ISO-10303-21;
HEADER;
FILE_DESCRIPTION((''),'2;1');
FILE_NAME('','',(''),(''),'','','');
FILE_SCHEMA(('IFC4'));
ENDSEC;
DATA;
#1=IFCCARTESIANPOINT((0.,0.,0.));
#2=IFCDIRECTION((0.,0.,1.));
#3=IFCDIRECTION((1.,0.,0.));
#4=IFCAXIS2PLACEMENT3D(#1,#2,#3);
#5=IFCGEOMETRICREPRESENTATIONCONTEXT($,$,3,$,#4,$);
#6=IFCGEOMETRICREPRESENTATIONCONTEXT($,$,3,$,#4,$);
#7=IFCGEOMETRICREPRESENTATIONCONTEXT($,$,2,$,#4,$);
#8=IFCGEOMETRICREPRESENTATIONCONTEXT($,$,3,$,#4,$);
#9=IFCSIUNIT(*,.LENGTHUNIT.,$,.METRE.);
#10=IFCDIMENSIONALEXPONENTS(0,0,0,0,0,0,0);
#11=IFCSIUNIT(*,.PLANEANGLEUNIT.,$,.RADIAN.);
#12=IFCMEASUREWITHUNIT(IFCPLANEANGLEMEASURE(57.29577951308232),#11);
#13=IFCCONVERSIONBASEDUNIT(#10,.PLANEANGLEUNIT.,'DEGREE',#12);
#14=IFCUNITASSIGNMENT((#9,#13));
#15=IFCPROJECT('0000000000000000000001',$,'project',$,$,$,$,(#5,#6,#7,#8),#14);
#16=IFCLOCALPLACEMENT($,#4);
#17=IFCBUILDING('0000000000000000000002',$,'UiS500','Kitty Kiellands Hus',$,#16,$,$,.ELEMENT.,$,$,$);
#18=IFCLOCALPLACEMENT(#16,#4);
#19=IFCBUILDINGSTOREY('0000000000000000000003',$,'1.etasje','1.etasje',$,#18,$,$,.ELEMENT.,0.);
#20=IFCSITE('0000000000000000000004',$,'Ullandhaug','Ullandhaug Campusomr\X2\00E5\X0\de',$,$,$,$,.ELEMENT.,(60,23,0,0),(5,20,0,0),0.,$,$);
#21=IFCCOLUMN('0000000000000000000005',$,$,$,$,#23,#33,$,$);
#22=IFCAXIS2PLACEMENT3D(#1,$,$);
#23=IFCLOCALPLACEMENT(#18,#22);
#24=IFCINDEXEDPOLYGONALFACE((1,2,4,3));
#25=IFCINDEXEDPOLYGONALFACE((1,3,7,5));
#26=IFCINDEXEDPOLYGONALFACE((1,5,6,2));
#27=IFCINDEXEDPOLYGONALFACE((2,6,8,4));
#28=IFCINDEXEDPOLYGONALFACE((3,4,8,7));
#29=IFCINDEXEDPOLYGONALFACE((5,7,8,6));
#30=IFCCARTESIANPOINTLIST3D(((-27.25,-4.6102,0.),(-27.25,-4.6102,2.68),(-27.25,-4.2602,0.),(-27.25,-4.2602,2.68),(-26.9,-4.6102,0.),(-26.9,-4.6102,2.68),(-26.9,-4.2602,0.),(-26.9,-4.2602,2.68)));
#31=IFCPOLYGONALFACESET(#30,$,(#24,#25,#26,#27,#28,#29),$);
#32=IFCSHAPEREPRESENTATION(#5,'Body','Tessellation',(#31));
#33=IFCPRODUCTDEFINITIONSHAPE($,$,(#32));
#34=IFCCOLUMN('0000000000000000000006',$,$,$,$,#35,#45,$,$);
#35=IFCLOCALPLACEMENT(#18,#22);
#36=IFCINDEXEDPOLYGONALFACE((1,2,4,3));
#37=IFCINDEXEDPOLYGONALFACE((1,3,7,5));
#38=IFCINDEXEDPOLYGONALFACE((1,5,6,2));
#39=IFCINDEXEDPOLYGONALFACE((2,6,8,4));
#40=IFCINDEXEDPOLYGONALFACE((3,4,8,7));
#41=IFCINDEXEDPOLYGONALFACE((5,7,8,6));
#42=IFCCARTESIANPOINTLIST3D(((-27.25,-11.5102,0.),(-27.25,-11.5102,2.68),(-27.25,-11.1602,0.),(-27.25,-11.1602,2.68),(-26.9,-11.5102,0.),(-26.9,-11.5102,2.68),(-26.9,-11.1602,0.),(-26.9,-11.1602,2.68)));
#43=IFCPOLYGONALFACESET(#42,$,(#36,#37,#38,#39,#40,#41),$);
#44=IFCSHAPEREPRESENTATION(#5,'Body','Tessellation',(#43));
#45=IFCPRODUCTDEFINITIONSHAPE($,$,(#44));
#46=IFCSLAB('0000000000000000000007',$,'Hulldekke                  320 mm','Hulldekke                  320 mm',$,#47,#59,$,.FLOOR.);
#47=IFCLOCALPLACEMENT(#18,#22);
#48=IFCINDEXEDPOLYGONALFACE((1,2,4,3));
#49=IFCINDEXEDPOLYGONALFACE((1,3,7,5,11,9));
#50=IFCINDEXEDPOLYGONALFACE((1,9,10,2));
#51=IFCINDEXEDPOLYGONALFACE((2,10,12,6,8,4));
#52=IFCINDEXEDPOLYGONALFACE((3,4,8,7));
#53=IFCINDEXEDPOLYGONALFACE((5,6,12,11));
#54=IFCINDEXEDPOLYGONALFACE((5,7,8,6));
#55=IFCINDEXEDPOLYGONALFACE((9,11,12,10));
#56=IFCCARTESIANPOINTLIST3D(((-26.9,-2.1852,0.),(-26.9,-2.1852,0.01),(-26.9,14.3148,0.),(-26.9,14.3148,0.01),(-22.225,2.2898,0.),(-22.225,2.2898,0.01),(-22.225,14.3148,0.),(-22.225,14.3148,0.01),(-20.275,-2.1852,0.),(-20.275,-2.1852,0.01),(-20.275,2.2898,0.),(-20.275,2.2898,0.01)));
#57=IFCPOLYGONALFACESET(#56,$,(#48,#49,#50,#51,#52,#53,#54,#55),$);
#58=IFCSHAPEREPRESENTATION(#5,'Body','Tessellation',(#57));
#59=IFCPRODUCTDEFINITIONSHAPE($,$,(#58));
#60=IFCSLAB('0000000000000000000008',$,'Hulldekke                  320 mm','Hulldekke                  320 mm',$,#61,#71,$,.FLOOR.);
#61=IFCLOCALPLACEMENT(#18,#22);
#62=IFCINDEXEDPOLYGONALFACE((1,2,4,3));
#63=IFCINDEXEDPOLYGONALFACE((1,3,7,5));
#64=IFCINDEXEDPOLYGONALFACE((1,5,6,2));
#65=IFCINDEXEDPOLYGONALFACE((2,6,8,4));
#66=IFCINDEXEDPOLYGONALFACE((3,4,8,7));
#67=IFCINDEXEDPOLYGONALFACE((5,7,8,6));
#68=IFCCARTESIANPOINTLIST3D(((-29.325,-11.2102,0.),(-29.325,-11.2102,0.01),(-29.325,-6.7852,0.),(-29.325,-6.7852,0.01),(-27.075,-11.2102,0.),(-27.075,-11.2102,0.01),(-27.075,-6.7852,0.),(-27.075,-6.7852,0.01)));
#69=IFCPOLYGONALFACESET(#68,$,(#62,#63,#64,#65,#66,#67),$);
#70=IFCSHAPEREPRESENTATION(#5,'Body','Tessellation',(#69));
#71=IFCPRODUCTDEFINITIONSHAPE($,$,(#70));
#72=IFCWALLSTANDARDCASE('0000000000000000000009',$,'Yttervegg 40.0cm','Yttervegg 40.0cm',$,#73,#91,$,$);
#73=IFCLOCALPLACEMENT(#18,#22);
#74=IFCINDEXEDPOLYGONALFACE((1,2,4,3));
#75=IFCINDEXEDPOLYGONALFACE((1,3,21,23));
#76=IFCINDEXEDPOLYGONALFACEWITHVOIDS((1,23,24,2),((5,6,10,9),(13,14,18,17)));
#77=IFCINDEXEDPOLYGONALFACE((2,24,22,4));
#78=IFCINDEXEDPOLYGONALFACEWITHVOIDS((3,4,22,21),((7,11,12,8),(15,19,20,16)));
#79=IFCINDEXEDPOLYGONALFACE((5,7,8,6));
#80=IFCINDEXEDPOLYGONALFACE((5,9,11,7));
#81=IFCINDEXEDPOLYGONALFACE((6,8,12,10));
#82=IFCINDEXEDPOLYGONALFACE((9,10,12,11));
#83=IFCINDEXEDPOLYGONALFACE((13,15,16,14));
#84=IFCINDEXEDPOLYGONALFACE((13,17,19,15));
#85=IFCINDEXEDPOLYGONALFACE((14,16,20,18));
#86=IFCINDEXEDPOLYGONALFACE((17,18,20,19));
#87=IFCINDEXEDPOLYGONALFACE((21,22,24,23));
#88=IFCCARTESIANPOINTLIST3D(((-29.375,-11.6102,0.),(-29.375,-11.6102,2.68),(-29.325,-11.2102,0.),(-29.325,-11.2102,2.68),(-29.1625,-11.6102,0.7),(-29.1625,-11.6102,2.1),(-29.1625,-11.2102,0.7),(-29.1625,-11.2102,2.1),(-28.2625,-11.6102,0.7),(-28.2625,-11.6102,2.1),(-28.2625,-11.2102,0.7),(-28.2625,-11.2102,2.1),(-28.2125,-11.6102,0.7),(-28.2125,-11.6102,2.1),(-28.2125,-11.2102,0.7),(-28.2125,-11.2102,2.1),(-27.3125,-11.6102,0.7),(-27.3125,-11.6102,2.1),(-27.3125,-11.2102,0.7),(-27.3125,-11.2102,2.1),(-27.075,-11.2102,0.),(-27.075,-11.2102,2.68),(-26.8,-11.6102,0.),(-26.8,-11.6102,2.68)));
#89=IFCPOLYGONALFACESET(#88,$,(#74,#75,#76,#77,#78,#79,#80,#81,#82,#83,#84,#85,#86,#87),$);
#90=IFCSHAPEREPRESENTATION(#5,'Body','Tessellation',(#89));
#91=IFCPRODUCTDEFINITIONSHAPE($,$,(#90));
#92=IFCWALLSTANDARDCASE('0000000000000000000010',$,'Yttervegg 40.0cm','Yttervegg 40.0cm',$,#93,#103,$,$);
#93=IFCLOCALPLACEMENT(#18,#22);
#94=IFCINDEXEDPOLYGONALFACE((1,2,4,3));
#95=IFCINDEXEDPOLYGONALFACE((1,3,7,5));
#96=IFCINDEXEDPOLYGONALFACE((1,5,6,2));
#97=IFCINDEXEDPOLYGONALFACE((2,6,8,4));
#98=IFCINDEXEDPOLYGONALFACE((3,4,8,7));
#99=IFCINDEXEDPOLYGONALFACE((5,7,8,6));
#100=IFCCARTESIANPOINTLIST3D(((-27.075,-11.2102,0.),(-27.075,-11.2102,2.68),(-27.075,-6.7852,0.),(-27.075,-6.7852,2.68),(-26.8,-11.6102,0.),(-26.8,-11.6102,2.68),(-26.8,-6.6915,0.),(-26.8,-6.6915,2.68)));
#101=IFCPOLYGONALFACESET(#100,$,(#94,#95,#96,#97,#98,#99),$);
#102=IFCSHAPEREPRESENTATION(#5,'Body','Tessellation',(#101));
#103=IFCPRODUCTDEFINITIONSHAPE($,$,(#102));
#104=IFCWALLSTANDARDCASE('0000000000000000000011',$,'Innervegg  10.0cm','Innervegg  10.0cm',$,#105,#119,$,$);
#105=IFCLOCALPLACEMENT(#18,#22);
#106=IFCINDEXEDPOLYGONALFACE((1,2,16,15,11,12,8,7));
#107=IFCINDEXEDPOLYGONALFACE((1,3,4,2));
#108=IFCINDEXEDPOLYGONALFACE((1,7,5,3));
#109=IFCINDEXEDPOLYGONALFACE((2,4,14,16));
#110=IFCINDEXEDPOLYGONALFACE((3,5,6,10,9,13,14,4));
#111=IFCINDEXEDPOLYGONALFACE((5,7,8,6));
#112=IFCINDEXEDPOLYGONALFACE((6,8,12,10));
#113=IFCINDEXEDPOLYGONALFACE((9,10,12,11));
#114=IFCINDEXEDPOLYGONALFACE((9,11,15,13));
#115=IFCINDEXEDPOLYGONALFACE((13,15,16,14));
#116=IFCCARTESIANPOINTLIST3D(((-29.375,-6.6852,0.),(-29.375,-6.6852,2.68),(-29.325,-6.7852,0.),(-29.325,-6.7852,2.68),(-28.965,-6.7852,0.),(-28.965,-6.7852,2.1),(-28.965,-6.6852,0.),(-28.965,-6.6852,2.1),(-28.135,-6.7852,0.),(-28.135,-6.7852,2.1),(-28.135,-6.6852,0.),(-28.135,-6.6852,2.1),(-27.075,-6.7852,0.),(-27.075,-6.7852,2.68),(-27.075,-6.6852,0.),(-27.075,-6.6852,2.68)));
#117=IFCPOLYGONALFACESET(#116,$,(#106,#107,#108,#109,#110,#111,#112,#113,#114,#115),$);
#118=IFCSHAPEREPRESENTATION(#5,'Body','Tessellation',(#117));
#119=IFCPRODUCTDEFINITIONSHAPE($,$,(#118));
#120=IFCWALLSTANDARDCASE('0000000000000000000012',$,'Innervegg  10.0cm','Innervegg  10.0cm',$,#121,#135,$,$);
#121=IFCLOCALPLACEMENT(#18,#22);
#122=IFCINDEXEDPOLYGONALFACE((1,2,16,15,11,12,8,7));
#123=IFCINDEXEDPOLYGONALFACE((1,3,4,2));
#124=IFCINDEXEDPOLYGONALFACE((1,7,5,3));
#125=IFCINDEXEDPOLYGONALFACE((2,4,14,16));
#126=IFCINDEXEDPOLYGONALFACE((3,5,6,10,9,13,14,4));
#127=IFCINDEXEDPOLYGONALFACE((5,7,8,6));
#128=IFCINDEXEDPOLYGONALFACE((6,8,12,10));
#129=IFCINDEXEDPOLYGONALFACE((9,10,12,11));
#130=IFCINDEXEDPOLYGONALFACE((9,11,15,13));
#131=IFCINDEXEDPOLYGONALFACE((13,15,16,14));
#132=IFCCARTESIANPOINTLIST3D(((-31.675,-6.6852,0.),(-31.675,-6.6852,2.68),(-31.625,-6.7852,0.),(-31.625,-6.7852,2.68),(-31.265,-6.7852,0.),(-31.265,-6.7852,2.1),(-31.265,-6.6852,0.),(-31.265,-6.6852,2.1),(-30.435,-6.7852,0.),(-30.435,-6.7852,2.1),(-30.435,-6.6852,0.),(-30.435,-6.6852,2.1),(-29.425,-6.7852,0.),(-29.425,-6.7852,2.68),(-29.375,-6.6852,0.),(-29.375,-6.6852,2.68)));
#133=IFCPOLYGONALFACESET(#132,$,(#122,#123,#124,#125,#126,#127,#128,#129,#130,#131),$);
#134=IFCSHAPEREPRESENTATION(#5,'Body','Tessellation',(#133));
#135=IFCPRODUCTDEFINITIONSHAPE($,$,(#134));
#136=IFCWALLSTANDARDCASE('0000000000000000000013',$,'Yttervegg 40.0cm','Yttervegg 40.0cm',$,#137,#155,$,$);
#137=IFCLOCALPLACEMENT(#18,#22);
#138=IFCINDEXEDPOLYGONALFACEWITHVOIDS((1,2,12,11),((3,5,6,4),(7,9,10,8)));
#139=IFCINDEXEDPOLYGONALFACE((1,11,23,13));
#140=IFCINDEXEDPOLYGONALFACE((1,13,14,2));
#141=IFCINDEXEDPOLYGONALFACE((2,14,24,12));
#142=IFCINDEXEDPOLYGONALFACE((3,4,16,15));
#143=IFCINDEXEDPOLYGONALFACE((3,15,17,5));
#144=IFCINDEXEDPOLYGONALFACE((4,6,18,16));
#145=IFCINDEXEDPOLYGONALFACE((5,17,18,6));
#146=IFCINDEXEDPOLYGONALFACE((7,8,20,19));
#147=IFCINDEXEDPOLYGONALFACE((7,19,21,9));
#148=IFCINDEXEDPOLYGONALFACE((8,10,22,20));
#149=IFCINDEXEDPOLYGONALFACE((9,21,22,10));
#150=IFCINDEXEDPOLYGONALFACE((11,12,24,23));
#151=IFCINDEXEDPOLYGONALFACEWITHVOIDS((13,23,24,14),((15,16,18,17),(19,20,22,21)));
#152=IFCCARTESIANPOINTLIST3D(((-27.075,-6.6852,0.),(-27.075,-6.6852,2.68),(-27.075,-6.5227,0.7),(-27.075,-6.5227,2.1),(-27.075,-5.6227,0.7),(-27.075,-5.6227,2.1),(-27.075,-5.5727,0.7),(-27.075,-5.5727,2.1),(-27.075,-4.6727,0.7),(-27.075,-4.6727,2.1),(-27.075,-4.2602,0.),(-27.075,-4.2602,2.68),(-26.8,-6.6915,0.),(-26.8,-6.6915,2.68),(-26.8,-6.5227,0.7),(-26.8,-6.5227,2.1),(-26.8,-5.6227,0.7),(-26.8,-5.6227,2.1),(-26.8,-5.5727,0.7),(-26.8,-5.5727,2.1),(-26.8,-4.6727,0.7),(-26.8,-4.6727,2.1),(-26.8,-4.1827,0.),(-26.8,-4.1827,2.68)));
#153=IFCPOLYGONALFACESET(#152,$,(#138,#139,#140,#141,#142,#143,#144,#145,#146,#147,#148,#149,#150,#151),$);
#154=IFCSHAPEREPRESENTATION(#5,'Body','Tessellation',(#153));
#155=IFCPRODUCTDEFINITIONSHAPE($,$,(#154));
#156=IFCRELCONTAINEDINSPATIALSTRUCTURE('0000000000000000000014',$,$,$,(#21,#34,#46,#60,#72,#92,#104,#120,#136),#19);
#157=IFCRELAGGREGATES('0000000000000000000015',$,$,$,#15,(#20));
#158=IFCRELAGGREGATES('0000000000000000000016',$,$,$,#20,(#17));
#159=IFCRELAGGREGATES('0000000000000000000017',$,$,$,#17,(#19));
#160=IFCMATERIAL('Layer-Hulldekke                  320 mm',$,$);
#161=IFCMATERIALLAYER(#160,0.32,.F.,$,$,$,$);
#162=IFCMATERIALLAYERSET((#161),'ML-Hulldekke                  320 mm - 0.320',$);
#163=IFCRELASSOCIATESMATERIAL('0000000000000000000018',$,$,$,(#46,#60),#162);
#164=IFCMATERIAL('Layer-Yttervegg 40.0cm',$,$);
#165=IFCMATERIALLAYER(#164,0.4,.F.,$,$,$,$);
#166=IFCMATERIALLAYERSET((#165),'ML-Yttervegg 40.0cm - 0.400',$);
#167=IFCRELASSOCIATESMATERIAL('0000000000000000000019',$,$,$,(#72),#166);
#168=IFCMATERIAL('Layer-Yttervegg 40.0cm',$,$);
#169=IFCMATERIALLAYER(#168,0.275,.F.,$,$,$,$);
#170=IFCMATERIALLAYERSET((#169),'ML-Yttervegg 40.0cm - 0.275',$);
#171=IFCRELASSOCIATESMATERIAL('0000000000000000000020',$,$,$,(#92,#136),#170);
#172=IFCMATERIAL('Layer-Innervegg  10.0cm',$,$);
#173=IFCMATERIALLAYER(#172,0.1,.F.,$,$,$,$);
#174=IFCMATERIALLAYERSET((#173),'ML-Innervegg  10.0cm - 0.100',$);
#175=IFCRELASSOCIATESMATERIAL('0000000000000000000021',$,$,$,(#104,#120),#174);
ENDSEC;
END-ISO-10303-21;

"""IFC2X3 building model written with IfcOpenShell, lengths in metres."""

from ifc_helpers import new_model, entity, si_unit, converted_unit, frame, origin_with_axes, origin_2d_with_axis, place, context, project, spatial, polyline, rectangle, outline, extrude, material, layer, layer_set, layer_usage, element, save


model = new_model("IFC2X3")

# Units and contexts
context_of_model_1 = context(None, 3, world=origin_with_axes())
context_of_model_2 = context(None, 3, world=origin_with_axes())
context_of_model_3 = context(None, 2, world=origin_with_axes())
context_of_model_4 = context(None, 3, world=origin_with_axes())
ifc_project = project(units=[si_unit("LENGTHUNIT", "METRE"), converted_unit("PLANEANGLEUNIT", "DEGREE", entity("IfcPlaneAngleMeasure", 57.29577951308232), si_unit("PLANEANGLEUNIT", "RADIAN"), dimensions=[0, 0, 0, 0, 0, 0, 0])], contexts=[context_of_model_1, context_of_model_2, context_of_model_3, context_of_model_4])

# Site, building, storey
site = spatial("IfcSite", under=ifc_project, Name="Ullandhaug", Description="Ullandhaug Campusområde", CompositionType="ELEMENT", RefLatitude=(60, 23, 0, 0), RefLongitude=(5, 20, 0, 0), RefElevation=0.0)
building_placement = place(None, origin_with_axes())
building = spatial("IfcBuilding", under=site, at=building_placement, Name="UiS500", Description="Kitty Kiellands Hus", CompositionType="ELEMENT")
storey_placement = place(building_placement, origin_with_axes())
storey = spatial("IfcBuildingStorey", under=building, at=storey_placement, Name="1.etasje", Description="1.etasje", CompositionType="ELEMENT", Elevation=0.0)

# Columns
for number, where, z_axis, x_axis in (
    (1, (-27.075, -4.4352, 0.0), (0.0, 0.0, 1.0), (1.0, 0.0, 0.0)),
    (2, (-27.075, -11.3352, 0.0), (0.0, 0.0, 1.0), (1.0, 0.0, 0.0)),
):
    element("IfcColumn", number, at=place(storey_placement, frame(where, z_axis=z_axis, x_axis=x_axis)), inside=storey, context=context_of_model_1, shape_type="SweptSolid", body=[
        extrude(rectangle(XDim=0.35, YDim=0.35, at=origin_2d_with_axis()), origin_with_axes(), (0.0, 0.0, 1.0), 2.68),
    ])

# Slabs
ifc_material_1 = material(Name="Layer-Hulldekke                  320 mm")
ifc_layer_1 = layer(ifc_material_1, 0.32, ventilated=False)
ifc_layer_set_1 = layer_set([ifc_layer_1], Name="ML-Hulldekke                  320 mm - 0.320")
ifc_layer_usage_1 = layer_usage(ifc_layer_set_1, "AXIS2", "POSITIVE", 0.0)
slab_1_placement = place(storey_placement, frame((-26.9, -2.1852, 0.0), z_axis=(0.0, 0.0, 1.0), x_axis=(1.0, 0.0, 0.0)))
element("IfcSlab", 3, at=slab_1_placement, inside=storey, material=ifc_layer_usage_1, Name="Hulldekke                  320 mm", Description="Hulldekke                  320 mm", PredefinedType="FLOOR", context=context_of_model_1, shape_type="SweptSolid", body=[
    extrude(outline(polyline([(0.0, 0.0), (6.625, 0.0), (6.625, 4.475), (4.675, 4.475), (4.675, 16.5), (0.0, 16.5), (0.0, 0.0)])), origin_with_axes(), (0.0, 0.0, 1.0), 0.01),
])
slab_2_placement = place(storey_placement, frame((-29.325, -11.2102, 0.0), z_axis=(0.0, 0.0, 1.0), x_axis=(1.0, 0.0, 0.0)))
element("IfcSlab", 4, at=slab_2_placement, inside=storey, material=ifc_layer_usage_1, Name="Hulldekke                  320 mm", Description="Hulldekke                  320 mm", PredefinedType="FLOOR", context=context_of_model_1, shape_type="SweptSolid", body=[
    extrude(outline(polyline([(0.0, 0.0), (2.25, 0.0), (2.25, 4.425), (0.0, 4.425), (0.0, 0.0)])), origin_with_axes(), (0.0, 0.0, 1.0), 0.01),
])

# Wall, openings
ifc_material_2 = material(Name="Layer-Yttervegg 40.0cm")
ifc_layer_2 = layer(ifc_material_2, 0.4, ventilated=False)
ifc_layer_set_2 = layer_set([ifc_layer_2], Name="ML-Yttervegg 40.0cm - 0.400")
ifc_layer_usage_2 = layer_usage(ifc_layer_set_2, "AXIS2", "POSITIVE", 0.0)
wall_1_placement = place(storey_placement, frame((-29.375, -11.6102, 0.0), z_axis=(0.0, 0.0, 1.0), x_axis=(1.0, 0.0, 0.0)))
wall_1 = element("IfcWallStandardCase", 5, at=wall_1_placement, inside=storey, material=ifc_layer_usage_2, Name="Yttervegg 40.0cm", Description="Yttervegg 40.0cm", context=context_of_model_1, shape_type="SweptSolid", body=[
    extrude(outline(polyline([(0.0, 0.0), (2.575, 0.0), (2.3, 0.4), (0.05, 0.4), (0.0, 0.0)])), origin_with_axes(), (0.0, 0.0, 1.0), 2.68),
])
opening_1_placement = place(wall_1_placement, frame((0.2125, 0.4, 0.7), z_axis=(0.0, 0.0, 1.0), x_axis=(1.0, 0.0, 0.0)))
element("IfcOpeningElement", 6, at=opening_1_placement, cuts=wall_1, context=context_of_model_1, shape_type="SweptSolid", body=[
    extrude(outline(polyline([(0.0, 0.0), (1.4, 0.0), (1.4, 0.9), (0.0, 0.9), (0.0, 0.0)])), frame((0.0, 0.0, 0.0), z_axis=(0.0, 1.0, 0.0), x_axis=(0.0, 0.0, 1.0)), (0.0, 0.0, -1.0), 0.4),
])
opening_2_placement = place(wall_1_placement, frame((1.1625, 0.4, 0.7), z_axis=(0.0, 0.0, 1.0), x_axis=(1.0, 0.0, 0.0)))
element("IfcOpeningElement", 7, at=opening_2_placement, cuts=wall_1, context=context_of_model_1, shape_type="SweptSolid", body=[
    extrude(outline(polyline([(0.0, 0.0), (1.4, 0.0), (1.4, 0.9), (0.0, 0.9), (0.0, 0.0)])), frame((0.0, 0.0, 0.0), z_axis=(0.0, 1.0, 0.0), x_axis=(0.0, 0.0, 1.0)), (0.0, 0.0, -1.0), 0.4),
])

# Wall
ifc_material_3 = material(Name="Layer-Yttervegg 40.0cm")
ifc_layer_3 = layer(ifc_material_3, 0.275, ventilated=False)
ifc_layer_set_3 = layer_set([ifc_layer_3], Name="ML-Yttervegg 40.0cm - 0.275")
ifc_layer_usage_3 = layer_usage(ifc_layer_set_3, "AXIS2", "POSITIVE", 0.0)
wall_2_placement = place(storey_placement, frame((-26.8, -11.6102, 0.0), z_axis=(0.0, 0.0, 1.0), x_axis=(0.0, 1.0, 0.0)))
element("IfcWallStandardCase", 8, at=wall_2_placement, inside=storey, material=ifc_layer_usage_3, Name="Yttervegg 40.0cm", Description="Yttervegg 40.0cm", context=context_of_model_1, shape_type="SweptSolid", body=[
    extrude(outline(polyline([(0.0, 0.0), (4.9187, 0.0), (4.825, 0.275), (0.4, 0.275), (0.0, 0.0)])), frame((0.0, 0.0, 0.0), z_axis=(0.0, 0.0, 1.0), x_axis=(1.0, 0.0, 0.0)), (0.0, 0.0, 1.0), 2.68),
])

# Wall, opening
ifc_material_4 = material(Name="Layer-Innervegg  10.0cm")
ifc_layer_4 = layer(ifc_material_4, 0.1, ventilated=False)
ifc_layer_set_4 = layer_set([ifc_layer_4], Name="ML-Innervegg  10.0cm - 0.100")
ifc_layer_usage_4 = layer_usage(ifc_layer_set_4, "AXIS2", "POSITIVE", 0.0)
wall_3_placement = place(storey_placement, frame((-27.075, -6.6852, 0.0), z_axis=(0.0, 0.0, 1.0), x_axis=(-1.0, 0.0, 0.0)))
wall_3 = element("IfcWallStandardCase", 9, at=wall_3_placement, inside=storey, material=ifc_layer_usage_4, Name="Innervegg  10.0cm", Description="Innervegg  10.0cm", context=context_of_model_1, shape_type="SweptSolid", body=[
    extrude(outline(polyline([(0.0, 0.0), (2.3, 0.0), (2.25, 0.1), (0.0, 0.1), (0.0, 0.0)])), frame((0.0, 0.0, 0.0), z_axis=(0.0, 0.0, 1.0), x_axis=(1.0, 0.0, 0.0)), (0.0, 0.0, 1.0), 2.68),
])
opening_3_placement = place(wall_3_placement, frame((1.06, 0.1, 0.0), z_axis=(0.0, 0.0, 1.0), x_axis=(1.0, 0.0, 0.0)))
element("IfcOpeningElement", 10, at=opening_3_placement, cuts=wall_3, context=context_of_model_1, shape_type="SweptSolid", body=[
    extrude(outline(polyline([(0.0, 0.0), (2.1, 0.0), (2.1, 0.83), (0.0, 0.83), (0.0, 0.0)])), frame((0.0, 0.0, 0.0), z_axis=(0.0, 1.0, 0.0), x_axis=(0.0, 0.0, 1.0)), (0.0, 0.0, -1.0), 0.1),
])

# Wall, opening
wall_4_placement = place(storey_placement, frame((-29.375, -6.6852, 0.0), z_axis=(0.0, 0.0, 1.0), x_axis=(-1.0, 0.0, 0.0)))
wall_4 = element("IfcWallStandardCase", 11, at=wall_4_placement, inside=storey, material=ifc_layer_usage_4, Name="Innervegg  10.0cm", Description="Innervegg  10.0cm", context=context_of_model_1, shape_type="SweptSolid", body=[
    extrude(outline(polyline([(0.0, 0.0), (2.3, 0.0), (2.25, 0.1), (0.05, 0.1), (0.0, 0.0)])), frame((0.0, 0.0, 0.0), z_axis=(0.0, 0.0, 1.0), x_axis=(1.0, 0.0, 0.0)), (0.0, 0.0, 1.0), 2.68),
])
opening_4_placement = place(wall_4_placement, frame((1.06, 0.1, 0.0), z_axis=(0.0, 0.0, 1.0), x_axis=(1.0, 0.0, 0.0)))
element("IfcOpeningElement", 12, at=opening_4_placement, cuts=wall_4, context=context_of_model_1, shape_type="SweptSolid", body=[
    extrude(outline(polyline([(0.0, 0.0), (2.1, 0.0), (2.1, 0.83), (0.0, 0.83), (0.0, 0.0)])), frame((0.0, 0.0, 0.0), z_axis=(0.0, 1.0, 0.0), x_axis=(0.0, 0.0, 1.0)), (0.0, 0.0, -1.0), 0.1),
])

# Wall, openings
wall_5_placement = place(storey_placement, frame((-26.8, -6.6915, 0.0), z_axis=(0.0, 0.0, 1.0), x_axis=(0.0, 1.0, 0.0)))
wall_5 = element("IfcWallStandardCase", 13, at=wall_5_placement, inside=storey, material=ifc_layer_usage_3, Name="Yttervegg 40.0cm", Description="Yttervegg 40.0cm", context=context_of_model_1, shape_type="SweptSolid", body=[
    extrude(outline(polyline([(0.0, 0.0), (2.5088, 0.0), (2.4312, 0.275), (0.0062, 0.275), (0.0, 0.0)])), frame((0.0, 0.0, 0.0), z_axis=(0.0, 0.0, 1.0), x_axis=(1.0, 0.0, 0.0)), (0.0, 0.0, 1.0), 2.68),
])
opening_5_placement = place(wall_5_placement, frame((0.1687, 0.275, 0.7), z_axis=(0.0, 0.0, 1.0), x_axis=(1.0, 0.0, 0.0)))
element("IfcOpeningElement", 14, at=opening_5_placement, cuts=wall_5, context=context_of_model_1, shape_type="SweptSolid", body=[
    extrude(outline(polyline([(0.0, 0.0), (1.4, 0.0), (1.4, 0.9), (0.0, 0.9), (0.0, 0.0)])), frame((0.0, 0.0, 0.0), z_axis=(0.0, 1.0, 0.0), x_axis=(0.0, 0.0, 1.0)), (0.0, 0.0, -1.0), 0.275),
])
opening_6_placement = place(wall_5_placement, frame((1.1187, 0.275, 0.7), z_axis=(0.0, 0.0, 1.0), x_axis=(1.0, 0.0, 0.0)))
element("IfcOpeningElement", 15, at=opening_6_placement, cuts=wall_5, context=context_of_model_1, shape_type="SweptSolid", body=[
    extrude(outline(polyline([(0.0, 0.0), (1.4, 0.0), (1.4, 0.9), (0.0, 0.9), (0.0, 0.0)])), frame((0.0, 0.0, 0.0), z_axis=(0.0, 1.0, 0.0), x_axis=(0.0, 0.0, 1.0)), (0.0, 0.0, -1.0), 0.275),
])

save(model, "model.ifc")
